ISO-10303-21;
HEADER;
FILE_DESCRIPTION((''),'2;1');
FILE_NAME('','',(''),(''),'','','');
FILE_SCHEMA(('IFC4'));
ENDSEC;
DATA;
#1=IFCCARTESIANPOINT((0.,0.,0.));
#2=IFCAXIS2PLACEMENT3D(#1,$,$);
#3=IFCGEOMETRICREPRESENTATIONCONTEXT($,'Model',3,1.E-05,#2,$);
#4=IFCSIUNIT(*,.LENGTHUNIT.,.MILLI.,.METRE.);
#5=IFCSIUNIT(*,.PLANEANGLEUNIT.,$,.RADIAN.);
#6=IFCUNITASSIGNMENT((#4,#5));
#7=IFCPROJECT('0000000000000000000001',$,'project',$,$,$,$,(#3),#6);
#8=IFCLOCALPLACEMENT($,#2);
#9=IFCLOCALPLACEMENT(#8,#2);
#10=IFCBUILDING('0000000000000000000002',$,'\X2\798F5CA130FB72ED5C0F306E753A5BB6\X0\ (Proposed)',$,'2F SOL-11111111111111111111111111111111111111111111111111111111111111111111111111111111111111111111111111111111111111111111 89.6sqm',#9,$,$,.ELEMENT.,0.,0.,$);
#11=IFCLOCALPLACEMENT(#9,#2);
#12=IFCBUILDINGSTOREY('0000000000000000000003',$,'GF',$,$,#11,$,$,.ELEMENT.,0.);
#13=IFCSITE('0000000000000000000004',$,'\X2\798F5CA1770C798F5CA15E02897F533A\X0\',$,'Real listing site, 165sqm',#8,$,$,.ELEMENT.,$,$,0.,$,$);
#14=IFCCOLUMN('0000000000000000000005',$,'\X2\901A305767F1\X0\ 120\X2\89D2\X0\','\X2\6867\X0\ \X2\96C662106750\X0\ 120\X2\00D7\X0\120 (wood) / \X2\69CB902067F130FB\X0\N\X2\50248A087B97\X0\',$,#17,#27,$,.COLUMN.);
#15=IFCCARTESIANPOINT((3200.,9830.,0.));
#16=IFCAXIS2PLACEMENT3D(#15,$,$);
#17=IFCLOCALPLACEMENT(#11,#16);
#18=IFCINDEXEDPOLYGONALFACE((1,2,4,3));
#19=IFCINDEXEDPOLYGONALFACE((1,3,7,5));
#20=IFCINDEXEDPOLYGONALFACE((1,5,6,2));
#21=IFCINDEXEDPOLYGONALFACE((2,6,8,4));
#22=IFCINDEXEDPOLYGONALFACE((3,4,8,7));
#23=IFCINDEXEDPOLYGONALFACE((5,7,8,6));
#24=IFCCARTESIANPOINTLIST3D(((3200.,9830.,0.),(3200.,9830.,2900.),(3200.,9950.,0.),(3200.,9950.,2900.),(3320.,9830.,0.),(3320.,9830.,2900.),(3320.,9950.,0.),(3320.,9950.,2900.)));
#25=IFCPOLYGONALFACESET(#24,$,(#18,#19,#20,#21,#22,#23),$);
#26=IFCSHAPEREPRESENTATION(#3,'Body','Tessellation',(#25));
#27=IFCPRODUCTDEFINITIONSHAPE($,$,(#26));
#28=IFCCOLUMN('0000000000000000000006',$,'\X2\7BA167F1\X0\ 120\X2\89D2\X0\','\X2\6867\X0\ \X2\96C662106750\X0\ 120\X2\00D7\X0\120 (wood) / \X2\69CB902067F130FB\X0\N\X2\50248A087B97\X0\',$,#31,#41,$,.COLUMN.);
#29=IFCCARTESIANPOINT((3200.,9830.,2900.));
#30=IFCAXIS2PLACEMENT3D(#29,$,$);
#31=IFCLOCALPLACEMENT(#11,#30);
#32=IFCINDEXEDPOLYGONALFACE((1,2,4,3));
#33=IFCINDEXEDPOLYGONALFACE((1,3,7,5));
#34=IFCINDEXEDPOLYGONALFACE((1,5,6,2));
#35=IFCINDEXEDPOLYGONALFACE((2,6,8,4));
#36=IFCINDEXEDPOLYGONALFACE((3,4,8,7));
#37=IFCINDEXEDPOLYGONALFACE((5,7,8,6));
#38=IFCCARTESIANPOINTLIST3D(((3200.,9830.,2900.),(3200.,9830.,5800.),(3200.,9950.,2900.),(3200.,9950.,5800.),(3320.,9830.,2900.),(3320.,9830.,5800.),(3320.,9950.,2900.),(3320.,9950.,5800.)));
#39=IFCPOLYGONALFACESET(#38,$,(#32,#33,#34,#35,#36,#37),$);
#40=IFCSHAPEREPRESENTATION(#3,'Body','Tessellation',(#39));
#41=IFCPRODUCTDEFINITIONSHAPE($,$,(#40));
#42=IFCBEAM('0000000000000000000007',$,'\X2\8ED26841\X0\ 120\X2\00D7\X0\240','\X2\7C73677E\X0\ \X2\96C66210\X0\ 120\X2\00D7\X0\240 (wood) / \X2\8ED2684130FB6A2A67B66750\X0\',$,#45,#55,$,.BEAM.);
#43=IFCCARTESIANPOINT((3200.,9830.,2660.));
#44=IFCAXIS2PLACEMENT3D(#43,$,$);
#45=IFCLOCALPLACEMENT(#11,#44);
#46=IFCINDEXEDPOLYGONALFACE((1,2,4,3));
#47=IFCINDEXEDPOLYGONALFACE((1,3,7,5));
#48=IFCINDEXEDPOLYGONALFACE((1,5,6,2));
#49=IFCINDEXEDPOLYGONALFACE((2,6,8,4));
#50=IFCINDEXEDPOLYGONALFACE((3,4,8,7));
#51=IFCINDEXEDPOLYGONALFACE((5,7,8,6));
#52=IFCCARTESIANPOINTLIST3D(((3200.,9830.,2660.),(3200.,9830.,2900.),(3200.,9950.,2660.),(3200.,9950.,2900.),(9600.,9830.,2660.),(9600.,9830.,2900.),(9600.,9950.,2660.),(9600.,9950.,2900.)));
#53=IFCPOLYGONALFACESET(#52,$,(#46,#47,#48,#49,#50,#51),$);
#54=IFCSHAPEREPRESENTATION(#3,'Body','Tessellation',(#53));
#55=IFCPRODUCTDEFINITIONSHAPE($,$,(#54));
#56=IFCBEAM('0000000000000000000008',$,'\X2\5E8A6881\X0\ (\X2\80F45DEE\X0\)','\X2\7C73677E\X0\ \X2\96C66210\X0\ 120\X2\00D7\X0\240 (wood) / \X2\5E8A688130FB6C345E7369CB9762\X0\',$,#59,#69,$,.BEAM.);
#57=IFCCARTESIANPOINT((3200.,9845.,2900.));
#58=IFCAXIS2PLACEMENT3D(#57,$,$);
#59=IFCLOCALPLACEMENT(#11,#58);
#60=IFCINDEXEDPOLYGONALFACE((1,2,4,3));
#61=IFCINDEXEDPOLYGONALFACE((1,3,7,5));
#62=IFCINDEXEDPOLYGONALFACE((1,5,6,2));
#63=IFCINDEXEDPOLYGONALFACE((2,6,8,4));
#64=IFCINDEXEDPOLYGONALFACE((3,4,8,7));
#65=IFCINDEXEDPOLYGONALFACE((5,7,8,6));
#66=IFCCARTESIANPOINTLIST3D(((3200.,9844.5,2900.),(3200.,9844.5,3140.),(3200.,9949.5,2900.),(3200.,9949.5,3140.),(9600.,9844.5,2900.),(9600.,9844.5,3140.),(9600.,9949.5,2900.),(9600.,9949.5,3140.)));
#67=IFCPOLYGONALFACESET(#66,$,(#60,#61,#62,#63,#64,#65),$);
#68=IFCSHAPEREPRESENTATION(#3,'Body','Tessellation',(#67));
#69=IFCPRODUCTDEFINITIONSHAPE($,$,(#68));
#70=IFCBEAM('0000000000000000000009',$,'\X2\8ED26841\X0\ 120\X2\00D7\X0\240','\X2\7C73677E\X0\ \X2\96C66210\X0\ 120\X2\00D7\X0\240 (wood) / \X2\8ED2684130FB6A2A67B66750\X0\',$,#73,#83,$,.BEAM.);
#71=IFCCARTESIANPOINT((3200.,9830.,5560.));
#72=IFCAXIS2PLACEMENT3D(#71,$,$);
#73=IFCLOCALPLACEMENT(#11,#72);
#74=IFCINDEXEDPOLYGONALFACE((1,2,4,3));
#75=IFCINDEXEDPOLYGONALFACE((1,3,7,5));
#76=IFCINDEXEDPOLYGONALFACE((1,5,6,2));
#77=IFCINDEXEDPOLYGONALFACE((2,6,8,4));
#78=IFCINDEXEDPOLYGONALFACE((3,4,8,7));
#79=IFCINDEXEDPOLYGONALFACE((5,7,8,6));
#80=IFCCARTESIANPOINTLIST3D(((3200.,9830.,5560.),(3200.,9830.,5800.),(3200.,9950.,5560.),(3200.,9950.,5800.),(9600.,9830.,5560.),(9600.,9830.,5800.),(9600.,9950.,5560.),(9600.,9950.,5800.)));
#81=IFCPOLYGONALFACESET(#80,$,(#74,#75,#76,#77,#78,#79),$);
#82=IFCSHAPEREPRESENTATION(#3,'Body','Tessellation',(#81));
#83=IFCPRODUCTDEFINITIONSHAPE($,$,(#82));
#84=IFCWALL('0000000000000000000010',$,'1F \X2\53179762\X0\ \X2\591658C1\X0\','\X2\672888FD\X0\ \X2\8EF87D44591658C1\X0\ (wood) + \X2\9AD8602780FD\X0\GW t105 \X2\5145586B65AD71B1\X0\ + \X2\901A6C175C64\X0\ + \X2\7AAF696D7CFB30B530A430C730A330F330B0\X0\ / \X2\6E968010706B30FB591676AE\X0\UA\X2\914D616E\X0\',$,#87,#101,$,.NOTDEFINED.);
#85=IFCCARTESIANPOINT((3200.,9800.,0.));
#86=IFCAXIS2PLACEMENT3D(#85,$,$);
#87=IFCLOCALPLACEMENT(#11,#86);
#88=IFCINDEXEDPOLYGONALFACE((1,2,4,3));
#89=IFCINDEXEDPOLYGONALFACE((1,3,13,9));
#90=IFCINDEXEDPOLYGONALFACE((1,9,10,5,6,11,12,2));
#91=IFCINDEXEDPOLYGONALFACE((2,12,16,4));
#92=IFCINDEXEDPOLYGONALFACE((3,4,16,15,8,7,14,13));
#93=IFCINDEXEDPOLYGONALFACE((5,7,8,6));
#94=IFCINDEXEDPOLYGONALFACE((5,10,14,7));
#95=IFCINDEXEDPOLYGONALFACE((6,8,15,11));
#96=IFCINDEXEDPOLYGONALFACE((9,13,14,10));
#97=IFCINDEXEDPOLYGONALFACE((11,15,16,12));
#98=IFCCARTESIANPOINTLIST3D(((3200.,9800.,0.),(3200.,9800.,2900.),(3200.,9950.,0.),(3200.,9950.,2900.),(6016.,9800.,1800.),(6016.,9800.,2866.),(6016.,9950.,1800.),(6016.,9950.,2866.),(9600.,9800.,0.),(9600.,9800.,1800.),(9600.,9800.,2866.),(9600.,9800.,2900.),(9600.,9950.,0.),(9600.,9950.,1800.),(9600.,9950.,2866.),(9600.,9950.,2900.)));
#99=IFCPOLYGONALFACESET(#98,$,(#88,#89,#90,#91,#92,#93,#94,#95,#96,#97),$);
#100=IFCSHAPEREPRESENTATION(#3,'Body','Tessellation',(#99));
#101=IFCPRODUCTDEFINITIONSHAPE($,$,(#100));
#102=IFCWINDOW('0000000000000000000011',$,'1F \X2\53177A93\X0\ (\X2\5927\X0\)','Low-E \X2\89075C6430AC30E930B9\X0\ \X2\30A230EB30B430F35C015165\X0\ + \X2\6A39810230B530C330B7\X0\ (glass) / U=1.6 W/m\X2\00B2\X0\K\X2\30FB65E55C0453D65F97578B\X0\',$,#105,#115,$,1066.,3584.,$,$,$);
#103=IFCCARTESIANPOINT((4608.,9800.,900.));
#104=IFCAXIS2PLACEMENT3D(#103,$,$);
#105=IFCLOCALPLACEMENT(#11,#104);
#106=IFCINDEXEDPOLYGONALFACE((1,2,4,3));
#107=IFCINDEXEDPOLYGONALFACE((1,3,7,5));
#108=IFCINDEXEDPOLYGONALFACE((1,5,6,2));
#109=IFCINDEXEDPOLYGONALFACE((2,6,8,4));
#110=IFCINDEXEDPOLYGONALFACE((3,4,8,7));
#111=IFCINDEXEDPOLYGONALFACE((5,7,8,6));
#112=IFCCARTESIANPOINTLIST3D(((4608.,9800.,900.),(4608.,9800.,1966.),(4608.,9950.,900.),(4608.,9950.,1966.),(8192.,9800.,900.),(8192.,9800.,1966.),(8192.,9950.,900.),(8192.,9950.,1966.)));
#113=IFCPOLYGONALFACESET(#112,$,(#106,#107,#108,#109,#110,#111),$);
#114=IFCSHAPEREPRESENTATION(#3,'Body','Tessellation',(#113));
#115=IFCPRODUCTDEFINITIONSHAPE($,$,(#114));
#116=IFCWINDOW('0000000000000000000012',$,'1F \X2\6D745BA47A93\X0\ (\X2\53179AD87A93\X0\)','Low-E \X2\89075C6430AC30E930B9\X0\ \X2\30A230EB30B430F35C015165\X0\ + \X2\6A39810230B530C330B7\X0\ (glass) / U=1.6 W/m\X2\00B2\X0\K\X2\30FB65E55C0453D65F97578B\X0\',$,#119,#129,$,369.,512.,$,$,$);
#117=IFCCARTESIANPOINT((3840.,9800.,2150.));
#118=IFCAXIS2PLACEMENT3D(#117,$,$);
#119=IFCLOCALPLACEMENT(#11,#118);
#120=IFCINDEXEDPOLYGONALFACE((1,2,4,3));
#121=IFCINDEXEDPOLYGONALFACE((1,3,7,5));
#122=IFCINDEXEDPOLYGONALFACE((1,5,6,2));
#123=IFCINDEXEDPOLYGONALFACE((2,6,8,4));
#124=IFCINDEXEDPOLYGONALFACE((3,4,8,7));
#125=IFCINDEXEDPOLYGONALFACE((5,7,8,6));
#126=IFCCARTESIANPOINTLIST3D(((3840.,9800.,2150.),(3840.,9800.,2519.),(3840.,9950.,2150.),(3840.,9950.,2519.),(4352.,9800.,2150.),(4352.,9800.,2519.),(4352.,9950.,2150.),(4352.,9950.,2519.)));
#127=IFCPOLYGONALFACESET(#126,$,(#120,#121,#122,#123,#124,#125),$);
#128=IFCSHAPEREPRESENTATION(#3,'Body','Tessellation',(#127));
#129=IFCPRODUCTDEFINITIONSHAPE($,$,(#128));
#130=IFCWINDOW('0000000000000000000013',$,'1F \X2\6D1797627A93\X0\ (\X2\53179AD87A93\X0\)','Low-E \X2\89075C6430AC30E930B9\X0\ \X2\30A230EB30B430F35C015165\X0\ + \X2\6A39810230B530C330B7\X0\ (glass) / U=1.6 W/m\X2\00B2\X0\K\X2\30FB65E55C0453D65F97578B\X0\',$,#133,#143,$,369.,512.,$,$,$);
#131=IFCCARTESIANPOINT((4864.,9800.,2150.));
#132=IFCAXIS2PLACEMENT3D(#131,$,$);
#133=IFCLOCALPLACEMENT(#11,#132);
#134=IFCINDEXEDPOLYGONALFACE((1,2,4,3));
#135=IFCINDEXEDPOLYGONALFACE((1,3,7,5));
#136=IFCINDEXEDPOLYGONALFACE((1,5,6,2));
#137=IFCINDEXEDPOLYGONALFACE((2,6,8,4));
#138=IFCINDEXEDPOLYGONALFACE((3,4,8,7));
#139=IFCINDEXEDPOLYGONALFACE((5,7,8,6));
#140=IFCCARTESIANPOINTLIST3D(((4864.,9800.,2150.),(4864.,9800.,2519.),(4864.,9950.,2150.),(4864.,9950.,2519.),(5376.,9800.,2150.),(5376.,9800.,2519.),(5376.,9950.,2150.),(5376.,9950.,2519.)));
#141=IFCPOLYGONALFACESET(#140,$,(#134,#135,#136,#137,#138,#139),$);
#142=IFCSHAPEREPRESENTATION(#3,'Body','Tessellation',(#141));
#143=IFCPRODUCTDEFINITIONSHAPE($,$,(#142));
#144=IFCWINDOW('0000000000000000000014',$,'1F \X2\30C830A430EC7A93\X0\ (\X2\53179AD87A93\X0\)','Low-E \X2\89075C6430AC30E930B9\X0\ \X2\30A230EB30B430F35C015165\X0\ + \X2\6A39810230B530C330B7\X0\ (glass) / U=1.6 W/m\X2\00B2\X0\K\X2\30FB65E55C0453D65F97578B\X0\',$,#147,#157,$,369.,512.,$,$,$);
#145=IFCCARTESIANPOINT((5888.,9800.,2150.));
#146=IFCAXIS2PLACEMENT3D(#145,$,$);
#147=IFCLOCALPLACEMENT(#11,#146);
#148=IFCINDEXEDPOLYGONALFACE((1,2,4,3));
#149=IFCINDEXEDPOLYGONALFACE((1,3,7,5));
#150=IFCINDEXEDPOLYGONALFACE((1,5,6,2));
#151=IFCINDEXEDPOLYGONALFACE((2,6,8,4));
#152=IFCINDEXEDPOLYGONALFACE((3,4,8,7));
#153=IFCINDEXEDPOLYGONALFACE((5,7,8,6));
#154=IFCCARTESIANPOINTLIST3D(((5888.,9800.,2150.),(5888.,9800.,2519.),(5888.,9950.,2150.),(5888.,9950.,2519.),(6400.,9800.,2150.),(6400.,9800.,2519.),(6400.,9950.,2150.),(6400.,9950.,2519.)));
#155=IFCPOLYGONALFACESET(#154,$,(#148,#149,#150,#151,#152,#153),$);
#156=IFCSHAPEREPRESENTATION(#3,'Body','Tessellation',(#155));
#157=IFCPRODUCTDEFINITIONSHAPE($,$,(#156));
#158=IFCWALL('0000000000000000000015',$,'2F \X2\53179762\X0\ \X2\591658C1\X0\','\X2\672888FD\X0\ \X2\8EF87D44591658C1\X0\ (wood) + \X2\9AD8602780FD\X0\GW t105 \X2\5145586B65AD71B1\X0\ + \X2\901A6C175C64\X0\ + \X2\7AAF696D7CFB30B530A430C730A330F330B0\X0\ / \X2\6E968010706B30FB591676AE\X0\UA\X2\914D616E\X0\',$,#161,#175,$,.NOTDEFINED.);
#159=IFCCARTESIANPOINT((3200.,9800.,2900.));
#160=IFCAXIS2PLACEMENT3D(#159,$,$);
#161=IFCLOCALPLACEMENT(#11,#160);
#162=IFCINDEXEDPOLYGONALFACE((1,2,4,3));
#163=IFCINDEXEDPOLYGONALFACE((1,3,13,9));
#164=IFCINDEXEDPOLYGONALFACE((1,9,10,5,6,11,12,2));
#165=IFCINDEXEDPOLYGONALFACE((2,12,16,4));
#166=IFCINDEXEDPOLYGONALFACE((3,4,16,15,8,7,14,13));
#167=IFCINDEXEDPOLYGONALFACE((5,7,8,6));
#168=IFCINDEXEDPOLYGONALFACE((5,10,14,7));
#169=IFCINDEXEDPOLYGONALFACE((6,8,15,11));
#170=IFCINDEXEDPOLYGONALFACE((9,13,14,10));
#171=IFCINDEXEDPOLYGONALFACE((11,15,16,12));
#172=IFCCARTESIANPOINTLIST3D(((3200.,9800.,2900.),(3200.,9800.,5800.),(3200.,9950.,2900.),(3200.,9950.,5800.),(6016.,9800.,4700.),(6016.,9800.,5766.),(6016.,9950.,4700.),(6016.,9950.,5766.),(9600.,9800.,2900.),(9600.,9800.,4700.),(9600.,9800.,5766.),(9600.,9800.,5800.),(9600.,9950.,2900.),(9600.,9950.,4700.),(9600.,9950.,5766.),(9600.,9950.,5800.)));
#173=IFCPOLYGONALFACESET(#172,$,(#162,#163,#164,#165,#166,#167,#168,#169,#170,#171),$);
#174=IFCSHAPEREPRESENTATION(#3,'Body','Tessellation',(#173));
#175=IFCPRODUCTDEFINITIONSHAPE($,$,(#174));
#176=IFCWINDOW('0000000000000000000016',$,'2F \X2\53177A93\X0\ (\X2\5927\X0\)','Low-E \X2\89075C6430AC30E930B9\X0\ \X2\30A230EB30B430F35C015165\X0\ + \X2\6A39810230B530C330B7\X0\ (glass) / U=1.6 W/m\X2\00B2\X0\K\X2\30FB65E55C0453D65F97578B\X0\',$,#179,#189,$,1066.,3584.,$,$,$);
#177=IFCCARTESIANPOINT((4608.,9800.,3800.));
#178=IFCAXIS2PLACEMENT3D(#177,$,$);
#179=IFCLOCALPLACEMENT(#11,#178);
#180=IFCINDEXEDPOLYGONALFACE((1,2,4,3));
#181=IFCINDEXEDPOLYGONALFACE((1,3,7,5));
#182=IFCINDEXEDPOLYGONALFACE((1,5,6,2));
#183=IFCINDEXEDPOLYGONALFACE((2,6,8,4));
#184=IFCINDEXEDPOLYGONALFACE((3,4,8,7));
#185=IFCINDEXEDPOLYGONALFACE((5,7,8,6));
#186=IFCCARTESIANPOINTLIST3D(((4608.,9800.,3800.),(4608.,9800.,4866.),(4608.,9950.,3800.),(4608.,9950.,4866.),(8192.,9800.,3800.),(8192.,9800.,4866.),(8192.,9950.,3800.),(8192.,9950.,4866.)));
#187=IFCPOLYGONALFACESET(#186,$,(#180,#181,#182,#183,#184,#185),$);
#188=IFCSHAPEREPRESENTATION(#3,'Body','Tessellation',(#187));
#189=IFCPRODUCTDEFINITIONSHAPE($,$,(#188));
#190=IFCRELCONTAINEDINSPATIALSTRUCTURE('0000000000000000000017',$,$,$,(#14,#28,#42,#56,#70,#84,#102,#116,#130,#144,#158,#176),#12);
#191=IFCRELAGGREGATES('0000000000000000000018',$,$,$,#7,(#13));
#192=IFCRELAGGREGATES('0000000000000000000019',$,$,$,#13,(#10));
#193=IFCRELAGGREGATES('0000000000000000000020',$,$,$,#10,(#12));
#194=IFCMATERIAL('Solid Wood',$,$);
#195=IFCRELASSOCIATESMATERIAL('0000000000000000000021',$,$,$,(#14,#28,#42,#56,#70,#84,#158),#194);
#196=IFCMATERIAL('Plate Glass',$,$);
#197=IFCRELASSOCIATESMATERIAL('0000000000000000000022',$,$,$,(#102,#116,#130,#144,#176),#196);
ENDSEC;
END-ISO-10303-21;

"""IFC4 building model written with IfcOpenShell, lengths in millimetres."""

from ifc_helpers import new_model, si_unit, frame, frame_2d, origin, place, context, project, spatial, rectangle, extrude, material, element, fill, save


model = new_model("IFC4")

# Units and contexts
model_context = context("Model", 3, precision=1e-05, world=origin())
ifc_project = project(units=[si_unit("LENGTHUNIT", "METRE", prefix="MILLI"), si_unit("PLANEANGLEUNIT", "RADIAN")], contexts=[model_context])

# Site, building, storey
site_placement = place(None, origin())
site = spatial("IfcSite", under=ifc_project, at=site_placement, Name="福岡県福岡市西区", ObjectType="Real listing site, 165sqm", CompositionType="ELEMENT", RefElevation=0.0)
building_placement = place(site_placement, origin())
building = spatial("IfcBuilding", under=site, at=building_placement, Name="福岡・狭小の町家 (Proposed)", ObjectType="2F SOL-11111111111111111111111111111111111111111111111111111111111111111111111111111111111111111111111111111111111111111111 89.6sqm", CompositionType="ELEMENT", ElevationOfRefHeight=0.0, ElevationOfTerrain=0.0)
storey_placement = place(building_placement, origin())
storey = spatial("IfcBuildingStorey", under=building, at=storey_placement, Name="GF", CompositionType="ELEMENT", Elevation=0.0)

# Columns
ifc_material_1 = material(Name="Solid Wood")
column_1_placement = place(storey_placement, frame((3200.0, 9830.0, 0.0)))
element("IfcColumn", 1, at=column_1_placement, inside=storey, material=ifc_material_1, Name="通し柱 120角", Description="桧 集成材 120×120 (wood) / 構造柱・N値計算", PredefinedType="COLUMN", context=model_context, shape_type="SweptSolid", body=[
    extrude(rectangle(XDim=120.0, YDim=120.0, at=frame_2d((60.0, 60.0))), frame((3200.0, 9830.0, 0.0)), (0.0, 0.0, 1.0), 2900.0),
])
column_2_placement = place(storey_placement, frame((3200.0, 9830.0, 2900.0)))
element("IfcColumn", 2, at=column_2_placement, inside=storey, material=ifc_material_1, Name="管柱 120角", Description="桧 集成材 120×120 (wood) / 構造柱・N値計算", PredefinedType="COLUMN", context=model_context, shape_type="SweptSolid", body=[
    extrude(rectangle(XDim=120.0, YDim=120.0, at=frame_2d((60.0, 60.0))), frame((3200.0, 9830.0, 2900.0)), (0.0, 0.0, 1.0), 2900.0),
])

# Beams
beam_1_placement = place(storey_placement, frame((3200.0, 9830.0, 2660.0)))
element("IfcBeam", 3, at=beam_1_placement, inside=storey, material=ifc_material_1, Name="軒桁 120×240", Description="米松 集成 120×240 (wood) / 軒桁・横架材", PredefinedType="BEAM", context=model_context, shape_type="SweptSolid", body=[
    extrude(rectangle(XDim=6400.0, YDim=120.0, at=frame_2d((3200.0, 60.0))), frame((3200.0, 9830.0, 2660.0)), (0.0, 0.0, 1.0), 240.0),
])
beam_2_placement = place(storey_placement, frame((3200.0, 9845.0, 2900.0)))
element("IfcBeam", 4, at=beam_2_placement, inside=storey, material=ifc_material_1, Name="床梁 (胴差)", Description="米松 集成 120×240 (wood) / 床梁・水平構面", PredefinedType="BEAM", context=model_context, shape_type="SweptSolid", body=[
    extrude(rectangle(XDim=6400.0, YDim=105.0, at=frame_2d((3200.0, 52.0))), frame((3200.0, 9845.0, 2900.0)), (0.0, 0.0, 1.0), 240.0),
])
beam_3_placement = place(storey_placement, frame((3200.0, 9830.0, 5560.0)))
element("IfcBeam", 5, at=beam_3_placement, inside=storey, material=ifc_material_1, Name="軒桁 120×240", Description="米松 集成 120×240 (wood) / 軒桁・横架材", PredefinedType="BEAM", context=model_context, shape_type="SweptSolid", body=[
    extrude(rectangle(XDim=6400.0, YDim=120.0, at=frame_2d((3200.0, 60.0))), frame((3200.0, 9830.0, 5560.0)), (0.0, 0.0, 1.0), 240.0),
])

# Wall, openings, windows
wall_1_placement = place(storey_placement, frame((3200.0, 9800.0, 0.0)))
wall_1 = element("IfcWall", 6, at=wall_1_placement, inside=storey, material=ifc_material_1, Name="1F 北面 外壁", Description="木製 軸組外壁 (wood) + 高性能GW t105 充填断熱 + 通気層 + 窯業系サイディング / 準耐火・外皮UA配慮", PredefinedType="NOTDEFINED", context=model_context, shape_type="SweptSolid", body=[
    extrude(rectangle(XDim=6400.0, YDim=150.0, at=frame_2d((3200.0, 75.0))), frame((3200.0, 9800.0, 0.0)), (0.0, 0.0, 1.0), 2900.0),
])
opening_1_placement = place(storey_placement, frame((4608.0, 9800.0, 900.0)))
opening_1 = element("IfcOpeningElement", 7, at=opening_1_placement, cuts=wall_1, PredefinedType="NOTDEFINED", context=model_context, shape_type="SweptSolid", body=[
    extrude(rectangle(XDim=3584.0, YDim=150.0, at=frame_2d((1792.0, 75.0))), frame((4608.0, 9800.0, 900.0)), (0.0, 0.0, 1.0), 1066.0),
])
opening_2_placement = place(storey_placement, frame((3840.0, 9800.0, 2150.0)))
opening_2 = element("IfcOpeningElement", 8, at=opening_2_placement, cuts=wall_1, PredefinedType="NOTDEFINED", context=model_context, shape_type="SweptSolid", body=[
    extrude(rectangle(XDim=512.0, YDim=150.0, at=frame_2d((256.0, 75.0))), frame((3840.0, 9800.0, 2150.0)), (0.0, 0.0, 1.0), 369.0),
])
opening_3_placement = place(storey_placement, frame((4864.0, 9800.0, 2150.0)))
opening_3 = element("IfcOpeningElement", 9, at=opening_3_placement, cuts=wall_1, PredefinedType="NOTDEFINED", context=model_context, shape_type="SweptSolid", body=[
    extrude(rectangle(XDim=512.0, YDim=150.0, at=frame_2d((256.0, 75.0))), frame((4864.0, 9800.0, 2150.0)), (0.0, 0.0, 1.0), 369.0),
])
opening_4_placement = place(storey_placement, frame((5888.0, 9800.0, 2150.0)))
opening_4 = element("IfcOpeningElement", 10, at=opening_4_placement, cuts=wall_1, PredefinedType="NOTDEFINED", context=model_context, shape_type="SweptSolid", body=[
    extrude(rectangle(XDim=512.0, YDim=150.0, at=frame_2d((256.0, 75.0))), frame((5888.0, 9800.0, 2150.0)), (0.0, 0.0, 1.0), 369.0),
])
ifc_material_2 = material(Name="Plate Glass")
window_1_placement = place(storey_placement, frame((4608.0, 9800.0, 900.0)))
window_1 = element("IfcWindow", 11, at=window_1_placement, inside=storey, material=ifc_material_2, Name="1F 北窓 (大)", Description="Low-E 複層ガラス アルゴン封入 + 樹脂サッシ (glass) / U=1.6 W/m²K・日射取得型", OverallHeight=1066.0, OverallWidth=3584.0, context=model_context, shape_type="SweptSolid", body=[
    extrude(rectangle(XDim=3584.0, YDim=150.0, at=frame_2d((1792.0, 75.0))), frame((4608.0, 9800.0, 900.0)), (0.0, 0.0, 1.0), 1066.0),
])
fill(opening_1, window_1)
window_2_placement = place(storey_placement, frame((3840.0, 9800.0, 2150.0)))
window_2 = element("IfcWindow", 12, at=window_2_placement, inside=storey, material=ifc_material_2, Name="1F 浴室窓 (北高窓)", Description="Low-E 複層ガラス アルゴン封入 + 樹脂サッシ (glass) / U=1.6 W/m²K・日射取得型", OverallHeight=369.0, OverallWidth=512.0, context=model_context, shape_type="SweptSolid", body=[
    extrude(rectangle(XDim=512.0, YDim=150.0, at=frame_2d((256.0, 75.0))), frame((3840.0, 9800.0, 2150.0)), (0.0, 0.0, 1.0), 369.0),
])
fill(opening_2, window_2)
window_3_placement = place(storey_placement, frame((4864.0, 9800.0, 2150.0)))
window_3 = element("IfcWindow", 13, at=window_3_placement, inside=storey, material=ifc_material_2, Name="1F 洗面窓 (北高窓)", Description="Low-E 複層ガラス アルゴン封入 + 樹脂サッシ (glass) / U=1.6 W/m²K・日射取得型", OverallHeight=369.0, OverallWidth=512.0, context=model_context, shape_type="SweptSolid", body=[
    extrude(rectangle(XDim=512.0, YDim=150.0, at=frame_2d((256.0, 75.0))), frame((4864.0, 9800.0, 2150.0)), (0.0, 0.0, 1.0), 369.0),
])
fill(opening_3, window_3)
window_4_placement = place(storey_placement, frame((5888.0, 9800.0, 2150.0)))
window_4 = element("IfcWindow", 14, at=window_4_placement, inside=storey, material=ifc_material_2, Name="1F トイレ窓 (北高窓)", Description="Low-E 複層ガラス アルゴン封入 + 樹脂サッシ (glass) / U=1.6 W/m²K・日射取得型", OverallHeight=369.0, OverallWidth=512.0, context=model_context, shape_type="SweptSolid", body=[
    extrude(rectangle(XDim=512.0, YDim=150.0, at=frame_2d((256.0, 75.0))), frame((5888.0, 9800.0, 2150.0)), (0.0, 0.0, 1.0), 369.0),
])
fill(opening_4, window_4)

# Wall, opening, window
wall_2_placement = place(storey_placement, frame((3200.0, 9800.0, 2900.0)))
wall_2 = element("IfcWall", 15, at=wall_2_placement, inside=storey, material=ifc_material_1, Name="2F 北面 外壁", Description="木製 軸組外壁 (wood) + 高性能GW t105 充填断熱 + 通気層 + 窯業系サイディング / 準耐火・外皮UA配慮", PredefinedType="NOTDEFINED", context=model_context, shape_type="SweptSolid", body=[
    extrude(rectangle(XDim=6400.0, YDim=150.0, at=frame_2d((3200.0, 75.0))), frame((3200.0, 9800.0, 2900.0)), (0.0, 0.0, 1.0), 2900.0),
])
opening_5_placement = place(storey_placement, frame((4608.0, 9800.0, 3800.0)))
opening_5 = element("IfcOpeningElement", 16, at=opening_5_placement, cuts=wall_2, PredefinedType="NOTDEFINED", context=model_context, shape_type="SweptSolid", body=[
    extrude(rectangle(XDim=3584.0, YDim=150.0, at=frame_2d((1792.0, 75.0))), frame((4608.0, 9800.0, 3800.0)), (0.0, 0.0, 1.0), 1066.0),
])
window_5_placement = place(storey_placement, frame((4608.0, 9800.0, 3800.0)))
window_5 = element("IfcWindow", 17, at=window_5_placement, inside=storey, material=ifc_material_2, Name="2F 北窓 (大)", Description="Low-E 複層ガラス アルゴン封入 + 樹脂サッシ (glass) / U=1.6 W/m²K・日射取得型", OverallHeight=1066.0, OverallWidth=3584.0, context=model_context, shape_type="SweptSolid", body=[
    extrude(rectangle(XDim=3584.0, YDim=150.0, at=frame_2d((1792.0, 75.0))), frame((4608.0, 9800.0, 3800.0)), (0.0, 0.0, 1.0), 1066.0),
])
fill(opening_5, window_5)

save(model, "model.ifc")
